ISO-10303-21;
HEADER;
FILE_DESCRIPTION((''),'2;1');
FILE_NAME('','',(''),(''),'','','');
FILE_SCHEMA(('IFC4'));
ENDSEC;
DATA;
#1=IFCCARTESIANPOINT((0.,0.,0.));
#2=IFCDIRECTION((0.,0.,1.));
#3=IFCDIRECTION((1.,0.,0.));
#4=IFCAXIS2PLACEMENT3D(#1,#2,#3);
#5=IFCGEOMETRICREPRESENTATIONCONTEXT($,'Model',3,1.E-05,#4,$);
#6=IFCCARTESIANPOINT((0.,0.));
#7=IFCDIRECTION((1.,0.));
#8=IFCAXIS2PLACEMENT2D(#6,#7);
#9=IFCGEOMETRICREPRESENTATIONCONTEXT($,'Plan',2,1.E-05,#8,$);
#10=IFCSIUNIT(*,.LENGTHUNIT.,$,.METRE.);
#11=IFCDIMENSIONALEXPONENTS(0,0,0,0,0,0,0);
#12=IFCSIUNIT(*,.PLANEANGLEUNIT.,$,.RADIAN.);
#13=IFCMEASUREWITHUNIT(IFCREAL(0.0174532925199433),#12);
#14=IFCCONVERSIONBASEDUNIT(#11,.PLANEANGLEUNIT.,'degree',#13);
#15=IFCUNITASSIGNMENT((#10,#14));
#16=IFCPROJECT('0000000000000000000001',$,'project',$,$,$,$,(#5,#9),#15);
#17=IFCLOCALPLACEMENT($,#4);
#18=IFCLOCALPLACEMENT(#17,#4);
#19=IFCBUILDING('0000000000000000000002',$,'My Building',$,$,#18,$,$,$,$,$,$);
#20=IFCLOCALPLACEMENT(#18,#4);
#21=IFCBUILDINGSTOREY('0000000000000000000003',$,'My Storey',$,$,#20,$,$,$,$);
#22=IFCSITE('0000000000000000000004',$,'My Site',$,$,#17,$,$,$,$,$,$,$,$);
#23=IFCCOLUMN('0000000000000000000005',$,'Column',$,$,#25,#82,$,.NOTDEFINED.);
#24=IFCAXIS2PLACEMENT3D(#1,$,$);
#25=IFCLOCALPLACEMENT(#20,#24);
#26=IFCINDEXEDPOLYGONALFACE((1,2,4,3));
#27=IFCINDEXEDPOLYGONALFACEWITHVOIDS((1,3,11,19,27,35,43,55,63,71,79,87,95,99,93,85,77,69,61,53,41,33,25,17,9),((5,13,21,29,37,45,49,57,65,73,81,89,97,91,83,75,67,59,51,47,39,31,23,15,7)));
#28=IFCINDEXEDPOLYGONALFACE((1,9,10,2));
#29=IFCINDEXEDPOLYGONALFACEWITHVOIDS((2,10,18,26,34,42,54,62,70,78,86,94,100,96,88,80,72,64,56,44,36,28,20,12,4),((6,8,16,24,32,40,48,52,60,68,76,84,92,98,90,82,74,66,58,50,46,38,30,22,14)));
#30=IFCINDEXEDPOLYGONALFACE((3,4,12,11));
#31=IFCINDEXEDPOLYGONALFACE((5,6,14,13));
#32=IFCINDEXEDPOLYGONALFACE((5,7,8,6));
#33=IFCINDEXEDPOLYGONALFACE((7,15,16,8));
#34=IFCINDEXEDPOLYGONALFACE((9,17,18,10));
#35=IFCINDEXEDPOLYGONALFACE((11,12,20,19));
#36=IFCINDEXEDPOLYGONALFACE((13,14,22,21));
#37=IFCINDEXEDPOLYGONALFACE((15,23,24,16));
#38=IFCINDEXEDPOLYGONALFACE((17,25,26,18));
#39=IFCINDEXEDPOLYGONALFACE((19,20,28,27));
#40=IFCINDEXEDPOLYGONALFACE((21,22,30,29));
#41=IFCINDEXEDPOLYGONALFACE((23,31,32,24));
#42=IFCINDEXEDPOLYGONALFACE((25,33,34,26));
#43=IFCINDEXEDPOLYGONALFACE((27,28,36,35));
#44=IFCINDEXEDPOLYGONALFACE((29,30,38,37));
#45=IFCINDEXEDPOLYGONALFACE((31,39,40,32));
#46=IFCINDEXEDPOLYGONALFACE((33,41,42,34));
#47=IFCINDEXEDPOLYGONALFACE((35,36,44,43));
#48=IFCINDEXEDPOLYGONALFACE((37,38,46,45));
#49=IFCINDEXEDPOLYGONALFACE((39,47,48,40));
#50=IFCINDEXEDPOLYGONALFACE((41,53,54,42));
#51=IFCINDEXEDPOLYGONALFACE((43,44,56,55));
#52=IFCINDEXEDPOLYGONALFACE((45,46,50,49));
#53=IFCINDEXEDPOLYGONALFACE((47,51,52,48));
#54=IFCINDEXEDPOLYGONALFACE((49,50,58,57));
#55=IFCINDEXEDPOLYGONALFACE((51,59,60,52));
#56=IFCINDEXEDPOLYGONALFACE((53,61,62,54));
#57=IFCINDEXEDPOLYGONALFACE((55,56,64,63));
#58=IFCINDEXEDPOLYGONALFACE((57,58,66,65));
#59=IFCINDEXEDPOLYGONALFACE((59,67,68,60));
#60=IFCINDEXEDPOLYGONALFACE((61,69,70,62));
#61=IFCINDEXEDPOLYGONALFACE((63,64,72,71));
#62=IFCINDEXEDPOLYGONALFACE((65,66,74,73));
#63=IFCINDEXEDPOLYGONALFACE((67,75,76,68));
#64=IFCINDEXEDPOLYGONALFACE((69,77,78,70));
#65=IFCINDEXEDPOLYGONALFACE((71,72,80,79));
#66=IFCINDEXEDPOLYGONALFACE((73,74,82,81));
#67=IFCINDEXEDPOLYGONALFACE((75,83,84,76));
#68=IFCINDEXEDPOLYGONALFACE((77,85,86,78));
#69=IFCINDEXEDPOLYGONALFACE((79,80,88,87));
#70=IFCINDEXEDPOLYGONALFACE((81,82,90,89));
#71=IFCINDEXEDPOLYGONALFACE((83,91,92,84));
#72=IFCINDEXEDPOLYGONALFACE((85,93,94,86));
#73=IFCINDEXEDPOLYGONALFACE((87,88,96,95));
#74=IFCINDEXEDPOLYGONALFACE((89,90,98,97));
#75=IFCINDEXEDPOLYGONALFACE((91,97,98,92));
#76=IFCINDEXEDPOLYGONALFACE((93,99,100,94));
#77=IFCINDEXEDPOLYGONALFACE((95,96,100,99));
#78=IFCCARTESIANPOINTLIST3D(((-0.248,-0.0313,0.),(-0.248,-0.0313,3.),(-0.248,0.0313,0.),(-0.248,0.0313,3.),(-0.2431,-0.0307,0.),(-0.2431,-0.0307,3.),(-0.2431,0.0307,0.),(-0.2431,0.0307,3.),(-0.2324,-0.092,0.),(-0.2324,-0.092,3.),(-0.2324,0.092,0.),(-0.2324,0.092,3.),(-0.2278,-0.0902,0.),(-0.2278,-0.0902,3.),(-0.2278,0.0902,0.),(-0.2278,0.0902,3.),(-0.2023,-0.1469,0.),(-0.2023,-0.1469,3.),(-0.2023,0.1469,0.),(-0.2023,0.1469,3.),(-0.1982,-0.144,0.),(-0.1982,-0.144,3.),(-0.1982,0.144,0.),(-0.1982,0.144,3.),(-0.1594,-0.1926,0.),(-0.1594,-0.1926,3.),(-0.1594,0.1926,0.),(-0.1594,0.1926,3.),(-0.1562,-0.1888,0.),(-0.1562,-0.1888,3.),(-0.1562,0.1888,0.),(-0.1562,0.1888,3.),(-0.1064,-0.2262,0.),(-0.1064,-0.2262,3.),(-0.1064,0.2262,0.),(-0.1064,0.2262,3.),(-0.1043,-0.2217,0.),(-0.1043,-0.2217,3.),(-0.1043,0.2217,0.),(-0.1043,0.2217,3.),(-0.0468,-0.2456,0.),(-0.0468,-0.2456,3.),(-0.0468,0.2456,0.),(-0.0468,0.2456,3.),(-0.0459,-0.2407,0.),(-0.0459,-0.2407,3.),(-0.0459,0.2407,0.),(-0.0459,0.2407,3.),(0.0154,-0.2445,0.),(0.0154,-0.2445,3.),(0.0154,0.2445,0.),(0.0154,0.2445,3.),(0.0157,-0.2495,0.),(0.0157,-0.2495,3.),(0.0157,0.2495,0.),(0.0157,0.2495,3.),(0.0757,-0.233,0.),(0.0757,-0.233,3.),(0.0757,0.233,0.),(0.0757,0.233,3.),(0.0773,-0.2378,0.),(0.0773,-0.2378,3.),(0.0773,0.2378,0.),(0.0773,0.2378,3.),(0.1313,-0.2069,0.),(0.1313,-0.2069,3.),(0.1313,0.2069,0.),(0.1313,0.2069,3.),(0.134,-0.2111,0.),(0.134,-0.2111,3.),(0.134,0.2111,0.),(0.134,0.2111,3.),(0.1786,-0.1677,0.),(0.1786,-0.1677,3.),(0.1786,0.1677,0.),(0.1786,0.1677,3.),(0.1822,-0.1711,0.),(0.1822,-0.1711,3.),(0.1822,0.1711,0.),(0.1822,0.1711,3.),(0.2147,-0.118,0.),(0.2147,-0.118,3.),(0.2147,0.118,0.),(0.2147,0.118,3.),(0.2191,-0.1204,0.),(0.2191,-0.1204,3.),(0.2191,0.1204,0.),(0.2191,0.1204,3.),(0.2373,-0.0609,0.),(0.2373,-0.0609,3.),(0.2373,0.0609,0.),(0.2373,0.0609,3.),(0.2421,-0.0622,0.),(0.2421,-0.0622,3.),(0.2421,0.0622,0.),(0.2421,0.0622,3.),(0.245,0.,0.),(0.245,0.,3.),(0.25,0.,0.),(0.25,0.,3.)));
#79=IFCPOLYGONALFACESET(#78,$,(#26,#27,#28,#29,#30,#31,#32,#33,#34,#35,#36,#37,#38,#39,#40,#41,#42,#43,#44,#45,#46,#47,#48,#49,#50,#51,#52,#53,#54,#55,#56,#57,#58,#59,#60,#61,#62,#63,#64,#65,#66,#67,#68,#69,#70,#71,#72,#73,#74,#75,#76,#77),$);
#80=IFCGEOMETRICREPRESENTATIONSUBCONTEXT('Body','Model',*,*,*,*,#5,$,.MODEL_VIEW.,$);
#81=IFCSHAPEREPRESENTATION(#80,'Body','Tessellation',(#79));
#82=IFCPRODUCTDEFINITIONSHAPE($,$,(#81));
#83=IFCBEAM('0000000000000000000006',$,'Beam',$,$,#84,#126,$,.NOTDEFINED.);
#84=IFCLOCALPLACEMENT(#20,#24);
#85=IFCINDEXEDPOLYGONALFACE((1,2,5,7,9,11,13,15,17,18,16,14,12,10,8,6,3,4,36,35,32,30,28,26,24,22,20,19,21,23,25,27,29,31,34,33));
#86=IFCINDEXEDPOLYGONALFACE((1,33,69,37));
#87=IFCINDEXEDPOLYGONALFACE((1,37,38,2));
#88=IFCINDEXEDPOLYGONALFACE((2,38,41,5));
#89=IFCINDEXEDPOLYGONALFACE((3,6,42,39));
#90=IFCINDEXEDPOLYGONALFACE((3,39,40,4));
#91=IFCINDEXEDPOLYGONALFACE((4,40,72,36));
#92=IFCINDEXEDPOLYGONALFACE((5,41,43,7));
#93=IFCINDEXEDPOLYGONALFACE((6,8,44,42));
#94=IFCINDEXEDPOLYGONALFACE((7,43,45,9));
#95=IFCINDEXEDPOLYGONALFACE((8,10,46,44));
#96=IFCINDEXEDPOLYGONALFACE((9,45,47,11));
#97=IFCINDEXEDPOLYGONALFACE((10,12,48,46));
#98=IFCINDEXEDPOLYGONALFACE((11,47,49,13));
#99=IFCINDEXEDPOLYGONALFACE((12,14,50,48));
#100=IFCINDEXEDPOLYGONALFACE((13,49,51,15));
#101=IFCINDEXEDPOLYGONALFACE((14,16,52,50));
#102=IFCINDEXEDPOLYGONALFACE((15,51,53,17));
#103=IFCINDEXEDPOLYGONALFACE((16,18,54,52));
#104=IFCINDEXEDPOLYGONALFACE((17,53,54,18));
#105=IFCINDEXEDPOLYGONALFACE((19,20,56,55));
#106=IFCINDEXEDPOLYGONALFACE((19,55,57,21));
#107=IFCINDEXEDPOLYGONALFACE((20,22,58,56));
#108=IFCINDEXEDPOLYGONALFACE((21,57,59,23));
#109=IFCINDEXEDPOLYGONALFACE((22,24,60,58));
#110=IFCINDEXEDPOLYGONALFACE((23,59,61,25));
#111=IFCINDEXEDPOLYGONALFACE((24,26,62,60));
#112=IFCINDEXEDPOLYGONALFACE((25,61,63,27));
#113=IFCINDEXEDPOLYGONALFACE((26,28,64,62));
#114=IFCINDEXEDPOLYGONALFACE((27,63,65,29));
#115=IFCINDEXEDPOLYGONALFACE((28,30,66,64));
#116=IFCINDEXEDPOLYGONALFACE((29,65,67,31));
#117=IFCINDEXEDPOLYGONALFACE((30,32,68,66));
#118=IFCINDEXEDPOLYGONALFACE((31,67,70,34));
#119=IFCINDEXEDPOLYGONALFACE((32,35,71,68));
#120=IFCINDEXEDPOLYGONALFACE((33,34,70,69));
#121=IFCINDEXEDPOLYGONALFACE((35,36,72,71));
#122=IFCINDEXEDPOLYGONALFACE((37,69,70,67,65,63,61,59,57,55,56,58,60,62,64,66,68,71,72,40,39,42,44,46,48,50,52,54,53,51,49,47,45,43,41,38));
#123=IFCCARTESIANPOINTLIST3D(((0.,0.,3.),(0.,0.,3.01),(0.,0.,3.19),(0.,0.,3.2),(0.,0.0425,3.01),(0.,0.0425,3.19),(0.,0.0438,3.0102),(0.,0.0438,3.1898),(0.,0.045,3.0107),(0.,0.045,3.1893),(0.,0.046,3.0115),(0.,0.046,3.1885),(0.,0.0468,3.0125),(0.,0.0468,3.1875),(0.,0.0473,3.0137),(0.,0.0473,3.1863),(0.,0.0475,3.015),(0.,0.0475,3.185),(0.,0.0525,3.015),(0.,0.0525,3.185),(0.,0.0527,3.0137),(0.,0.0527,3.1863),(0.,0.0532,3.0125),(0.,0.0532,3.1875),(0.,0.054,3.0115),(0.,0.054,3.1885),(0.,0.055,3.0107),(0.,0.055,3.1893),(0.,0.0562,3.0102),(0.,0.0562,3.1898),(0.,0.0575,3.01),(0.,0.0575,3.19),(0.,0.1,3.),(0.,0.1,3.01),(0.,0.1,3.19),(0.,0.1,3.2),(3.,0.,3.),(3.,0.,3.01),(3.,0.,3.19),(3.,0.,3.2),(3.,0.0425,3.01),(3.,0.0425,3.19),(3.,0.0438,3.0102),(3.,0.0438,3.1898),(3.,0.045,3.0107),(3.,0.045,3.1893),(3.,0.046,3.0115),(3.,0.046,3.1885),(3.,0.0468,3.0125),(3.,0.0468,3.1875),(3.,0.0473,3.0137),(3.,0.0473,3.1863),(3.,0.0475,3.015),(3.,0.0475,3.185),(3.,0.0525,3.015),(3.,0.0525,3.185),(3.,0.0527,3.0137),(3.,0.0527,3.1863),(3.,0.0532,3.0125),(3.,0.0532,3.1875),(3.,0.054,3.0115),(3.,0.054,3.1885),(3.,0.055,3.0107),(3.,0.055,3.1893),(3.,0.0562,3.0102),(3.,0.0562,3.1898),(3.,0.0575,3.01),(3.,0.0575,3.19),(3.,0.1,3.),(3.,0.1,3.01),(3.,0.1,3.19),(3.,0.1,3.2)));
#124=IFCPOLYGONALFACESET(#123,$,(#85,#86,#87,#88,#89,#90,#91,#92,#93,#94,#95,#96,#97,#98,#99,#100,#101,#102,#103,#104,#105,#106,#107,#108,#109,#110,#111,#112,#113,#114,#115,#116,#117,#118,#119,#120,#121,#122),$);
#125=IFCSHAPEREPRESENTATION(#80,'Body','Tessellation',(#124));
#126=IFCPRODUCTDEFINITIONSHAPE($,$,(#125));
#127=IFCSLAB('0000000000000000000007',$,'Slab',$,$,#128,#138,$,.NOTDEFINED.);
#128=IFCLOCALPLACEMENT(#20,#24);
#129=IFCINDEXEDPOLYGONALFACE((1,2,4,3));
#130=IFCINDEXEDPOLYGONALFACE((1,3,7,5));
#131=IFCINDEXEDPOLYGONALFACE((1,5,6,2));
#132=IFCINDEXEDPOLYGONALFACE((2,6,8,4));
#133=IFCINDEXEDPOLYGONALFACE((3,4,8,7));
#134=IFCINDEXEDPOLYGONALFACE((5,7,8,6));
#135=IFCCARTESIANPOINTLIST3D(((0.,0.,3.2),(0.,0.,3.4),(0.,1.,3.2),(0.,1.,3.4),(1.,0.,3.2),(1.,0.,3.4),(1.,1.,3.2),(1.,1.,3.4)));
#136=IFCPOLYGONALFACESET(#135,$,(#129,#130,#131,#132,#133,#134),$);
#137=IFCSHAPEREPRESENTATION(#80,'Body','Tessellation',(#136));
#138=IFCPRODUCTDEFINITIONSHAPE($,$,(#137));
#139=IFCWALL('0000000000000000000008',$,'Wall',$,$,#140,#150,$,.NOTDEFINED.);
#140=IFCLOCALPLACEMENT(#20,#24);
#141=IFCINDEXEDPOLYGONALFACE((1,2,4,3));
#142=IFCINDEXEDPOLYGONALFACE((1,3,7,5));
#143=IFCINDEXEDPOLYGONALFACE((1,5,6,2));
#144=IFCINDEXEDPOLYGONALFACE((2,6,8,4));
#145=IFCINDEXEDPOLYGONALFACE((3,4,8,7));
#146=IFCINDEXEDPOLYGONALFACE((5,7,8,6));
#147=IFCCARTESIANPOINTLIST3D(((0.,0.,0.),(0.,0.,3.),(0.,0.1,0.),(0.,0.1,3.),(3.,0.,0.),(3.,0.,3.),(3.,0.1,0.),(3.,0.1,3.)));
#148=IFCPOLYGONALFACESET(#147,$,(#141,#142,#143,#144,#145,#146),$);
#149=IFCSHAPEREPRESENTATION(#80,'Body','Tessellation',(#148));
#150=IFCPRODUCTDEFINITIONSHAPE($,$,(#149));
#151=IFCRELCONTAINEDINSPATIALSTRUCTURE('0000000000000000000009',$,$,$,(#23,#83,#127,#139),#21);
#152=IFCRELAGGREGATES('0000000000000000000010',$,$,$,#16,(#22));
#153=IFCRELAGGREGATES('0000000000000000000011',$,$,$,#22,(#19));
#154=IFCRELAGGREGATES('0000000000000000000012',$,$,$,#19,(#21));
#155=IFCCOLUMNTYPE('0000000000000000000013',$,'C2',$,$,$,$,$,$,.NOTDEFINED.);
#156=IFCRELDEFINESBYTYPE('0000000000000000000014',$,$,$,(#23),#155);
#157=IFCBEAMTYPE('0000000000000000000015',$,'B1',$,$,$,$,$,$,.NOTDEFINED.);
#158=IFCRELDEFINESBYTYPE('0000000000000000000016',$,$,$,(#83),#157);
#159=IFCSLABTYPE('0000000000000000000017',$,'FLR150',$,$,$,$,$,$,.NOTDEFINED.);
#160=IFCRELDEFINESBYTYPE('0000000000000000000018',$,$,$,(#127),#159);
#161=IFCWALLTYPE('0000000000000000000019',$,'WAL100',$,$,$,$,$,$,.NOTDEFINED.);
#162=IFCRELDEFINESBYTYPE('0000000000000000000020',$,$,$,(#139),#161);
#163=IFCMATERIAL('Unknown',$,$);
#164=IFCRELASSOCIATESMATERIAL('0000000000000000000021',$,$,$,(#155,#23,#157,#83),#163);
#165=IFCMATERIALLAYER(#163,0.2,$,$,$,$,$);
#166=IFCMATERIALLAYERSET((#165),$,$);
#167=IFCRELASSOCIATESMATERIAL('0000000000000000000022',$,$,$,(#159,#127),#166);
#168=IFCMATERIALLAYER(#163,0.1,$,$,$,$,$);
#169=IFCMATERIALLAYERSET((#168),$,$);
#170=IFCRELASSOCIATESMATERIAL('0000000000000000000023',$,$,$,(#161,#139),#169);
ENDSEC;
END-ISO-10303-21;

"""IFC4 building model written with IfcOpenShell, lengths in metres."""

from ifc_helpers import new_model, entity, si_unit, converted_unit, frame, origin_with_axes, origin_2d_with_axis, place, context, subcontext, project, spatial, indexed_curve, hollow_circle, i_section, outline, extrude, material, layer, layer_set, layer_usage, material_profile, profile_set, profile_usage, type_object, element, save


model = new_model("IFC4")

# Units and contexts
model_context = context("Model", 3, precision=1e-05, world=origin_with_axes())
plan_context = context("Plan", 2, precision=1e-05, world=origin_2d_with_axis())
body_context = subcontext(model_context, "Body", "Model", "MODEL_VIEW")
ifc_project = project(units=[si_unit("LENGTHUNIT", "METRE"), converted_unit("PLANEANGLEUNIT", "degree", entity("IfcReal", 0.0174532925199433), si_unit("PLANEANGLEUNIT", "RADIAN"), dimensions=[0, 0, 0, 0, 0, 0, 0])], contexts=[model_context, plan_context])

# Site, building, storey
site_placement = place(None, origin_with_axes())
site = spatial("IfcSite", under=ifc_project, at=site_placement, Name="My Site")
building_placement = place(site_placement, origin_with_axes())
building = spatial("IfcBuilding", under=site, at=building_placement, Name="My Building")
storey_placement = place(building_placement, origin_with_axes())
storey = spatial("IfcBuildingStorey", under=building, at=storey_placement, Name="My Storey")

# Column
ifc_material = material(Name="Unknown")
ifc_material_profile_1 = material_profile(ifc_material, hollow_circle(Radius=0.25, WallThickness=0.005))
ifc_profile_set_1 = profile_set([ifc_material_profile_1])
ifc_profile_usage_1 = profile_usage(ifc_profile_set_1, cardinal=5)
column_type = type_object("IfcColumnType", Name="C2", PredefinedType="NOTDEFINED", material=ifc_profile_set_1)
column_placement = place(storey_placement, origin_with_axes())
element("IfcColumn", 1, at=column_placement, inside=storey, type_object=column_type, material=ifc_profile_usage_1, Name="Column", PredefinedType="NOTDEFINED", context=body_context, shape_type="SweptSolid", body=[
    extrude(hollow_circle(Radius=0.25, WallThickness=0.005), origin_with_axes(), (0.0, 0.0, 1.0), 3.0),
])

# Beam
ifc_material_profile_2 = material_profile(ifc_material, i_section(OverallWidth=0.1, OverallDepth=0.2, WebThickness=0.005, FlangeThickness=0.01, FilletRadius=0.005))
ifc_profile_set_2 = profile_set([ifc_material_profile_2])
ifc_profile_usage_2 = profile_usage(ifc_profile_set_2, cardinal=5)
beam_type = type_object("IfcBeamType", Name="B1", PredefinedType="NOTDEFINED", material=ifc_profile_set_2)
beam_placement = place(storey_placement, frame((0.0, 0.05, 3.1), z_axis=(1.0, 0.0, 0.0), x_axis=(0.0, 1.0, 0.0)))
element("IfcBeam", 2, at=beam_placement, inside=storey, type_object=beam_type, material=ifc_profile_usage_2, Name="Beam", PredefinedType="NOTDEFINED", context=body_context, shape_type="SweptSolid", body=[
    extrude(i_section(OverallWidth=0.1, OverallDepth=0.2, WebThickness=0.005, FlangeThickness=0.01, FilletRadius=0.005), origin_with_axes(), (0.0, 0.0, 1.0), 3.0),
])

# Slab
ifc_layer_1 = layer(ifc_material, 0.2)
ifc_layer_set_1 = layer_set([ifc_layer_1])
ifc_layer_usage_1 = layer_usage(ifc_layer_set_1, "AXIS3", "POSITIVE", 0.0)
slab_type = type_object("IfcSlabType", Name="FLR150", PredefinedType="NOTDEFINED", material=ifc_layer_set_1)
slab_placement = place(storey_placement, frame((0.0, 0.0, 3.2), z_axis=(0.0, 0.0, 1.0), x_axis=(1.0, 0.0, 0.0)))
element("IfcSlab", 3, at=slab_placement, inside=storey, type_object=slab_type, material=ifc_layer_usage_1, Name="Slab", PredefinedType="NOTDEFINED", context=body_context, shape_type="SweptSolid", body=[
    extrude(outline(indexed_curve([(0.0, 0.0), (1.0, 0.0), (1.0, 1.0), (0.0, 1.0), (0.0, 0.0)])), None, (0.0, 0.0, 1.0), 0.2),
])

# Wall
ifc_layer_2 = layer(ifc_material, 0.1)
ifc_layer_set_2 = layer_set([ifc_layer_2])
ifc_layer_usage_2 = layer_usage(ifc_layer_set_2, "AXIS2", "POSITIVE", 0.0)
wall_type = type_object("IfcWallType", Name="WAL100", PredefinedType="NOTDEFINED", material=ifc_layer_set_2)
wall_placement = place(storey_placement, origin_with_axes())
element("IfcWall", 4, at=wall_placement, inside=storey, type_object=wall_type, material=ifc_layer_usage_2, Name="Wall", PredefinedType="NOTDEFINED", context=body_context, shape_type="SweptSolid", body=[
    extrude(outline(indexed_curve([(0.0, 0.0), (0.0, 0.1), (3.0, 0.1), (3.0, 0.0), (0.0, 0.0)], self_intersect=False)), origin_with_axes(), (0.0, 0.0, 1.0), 3.0),
])

save(model, "model.ifc")
